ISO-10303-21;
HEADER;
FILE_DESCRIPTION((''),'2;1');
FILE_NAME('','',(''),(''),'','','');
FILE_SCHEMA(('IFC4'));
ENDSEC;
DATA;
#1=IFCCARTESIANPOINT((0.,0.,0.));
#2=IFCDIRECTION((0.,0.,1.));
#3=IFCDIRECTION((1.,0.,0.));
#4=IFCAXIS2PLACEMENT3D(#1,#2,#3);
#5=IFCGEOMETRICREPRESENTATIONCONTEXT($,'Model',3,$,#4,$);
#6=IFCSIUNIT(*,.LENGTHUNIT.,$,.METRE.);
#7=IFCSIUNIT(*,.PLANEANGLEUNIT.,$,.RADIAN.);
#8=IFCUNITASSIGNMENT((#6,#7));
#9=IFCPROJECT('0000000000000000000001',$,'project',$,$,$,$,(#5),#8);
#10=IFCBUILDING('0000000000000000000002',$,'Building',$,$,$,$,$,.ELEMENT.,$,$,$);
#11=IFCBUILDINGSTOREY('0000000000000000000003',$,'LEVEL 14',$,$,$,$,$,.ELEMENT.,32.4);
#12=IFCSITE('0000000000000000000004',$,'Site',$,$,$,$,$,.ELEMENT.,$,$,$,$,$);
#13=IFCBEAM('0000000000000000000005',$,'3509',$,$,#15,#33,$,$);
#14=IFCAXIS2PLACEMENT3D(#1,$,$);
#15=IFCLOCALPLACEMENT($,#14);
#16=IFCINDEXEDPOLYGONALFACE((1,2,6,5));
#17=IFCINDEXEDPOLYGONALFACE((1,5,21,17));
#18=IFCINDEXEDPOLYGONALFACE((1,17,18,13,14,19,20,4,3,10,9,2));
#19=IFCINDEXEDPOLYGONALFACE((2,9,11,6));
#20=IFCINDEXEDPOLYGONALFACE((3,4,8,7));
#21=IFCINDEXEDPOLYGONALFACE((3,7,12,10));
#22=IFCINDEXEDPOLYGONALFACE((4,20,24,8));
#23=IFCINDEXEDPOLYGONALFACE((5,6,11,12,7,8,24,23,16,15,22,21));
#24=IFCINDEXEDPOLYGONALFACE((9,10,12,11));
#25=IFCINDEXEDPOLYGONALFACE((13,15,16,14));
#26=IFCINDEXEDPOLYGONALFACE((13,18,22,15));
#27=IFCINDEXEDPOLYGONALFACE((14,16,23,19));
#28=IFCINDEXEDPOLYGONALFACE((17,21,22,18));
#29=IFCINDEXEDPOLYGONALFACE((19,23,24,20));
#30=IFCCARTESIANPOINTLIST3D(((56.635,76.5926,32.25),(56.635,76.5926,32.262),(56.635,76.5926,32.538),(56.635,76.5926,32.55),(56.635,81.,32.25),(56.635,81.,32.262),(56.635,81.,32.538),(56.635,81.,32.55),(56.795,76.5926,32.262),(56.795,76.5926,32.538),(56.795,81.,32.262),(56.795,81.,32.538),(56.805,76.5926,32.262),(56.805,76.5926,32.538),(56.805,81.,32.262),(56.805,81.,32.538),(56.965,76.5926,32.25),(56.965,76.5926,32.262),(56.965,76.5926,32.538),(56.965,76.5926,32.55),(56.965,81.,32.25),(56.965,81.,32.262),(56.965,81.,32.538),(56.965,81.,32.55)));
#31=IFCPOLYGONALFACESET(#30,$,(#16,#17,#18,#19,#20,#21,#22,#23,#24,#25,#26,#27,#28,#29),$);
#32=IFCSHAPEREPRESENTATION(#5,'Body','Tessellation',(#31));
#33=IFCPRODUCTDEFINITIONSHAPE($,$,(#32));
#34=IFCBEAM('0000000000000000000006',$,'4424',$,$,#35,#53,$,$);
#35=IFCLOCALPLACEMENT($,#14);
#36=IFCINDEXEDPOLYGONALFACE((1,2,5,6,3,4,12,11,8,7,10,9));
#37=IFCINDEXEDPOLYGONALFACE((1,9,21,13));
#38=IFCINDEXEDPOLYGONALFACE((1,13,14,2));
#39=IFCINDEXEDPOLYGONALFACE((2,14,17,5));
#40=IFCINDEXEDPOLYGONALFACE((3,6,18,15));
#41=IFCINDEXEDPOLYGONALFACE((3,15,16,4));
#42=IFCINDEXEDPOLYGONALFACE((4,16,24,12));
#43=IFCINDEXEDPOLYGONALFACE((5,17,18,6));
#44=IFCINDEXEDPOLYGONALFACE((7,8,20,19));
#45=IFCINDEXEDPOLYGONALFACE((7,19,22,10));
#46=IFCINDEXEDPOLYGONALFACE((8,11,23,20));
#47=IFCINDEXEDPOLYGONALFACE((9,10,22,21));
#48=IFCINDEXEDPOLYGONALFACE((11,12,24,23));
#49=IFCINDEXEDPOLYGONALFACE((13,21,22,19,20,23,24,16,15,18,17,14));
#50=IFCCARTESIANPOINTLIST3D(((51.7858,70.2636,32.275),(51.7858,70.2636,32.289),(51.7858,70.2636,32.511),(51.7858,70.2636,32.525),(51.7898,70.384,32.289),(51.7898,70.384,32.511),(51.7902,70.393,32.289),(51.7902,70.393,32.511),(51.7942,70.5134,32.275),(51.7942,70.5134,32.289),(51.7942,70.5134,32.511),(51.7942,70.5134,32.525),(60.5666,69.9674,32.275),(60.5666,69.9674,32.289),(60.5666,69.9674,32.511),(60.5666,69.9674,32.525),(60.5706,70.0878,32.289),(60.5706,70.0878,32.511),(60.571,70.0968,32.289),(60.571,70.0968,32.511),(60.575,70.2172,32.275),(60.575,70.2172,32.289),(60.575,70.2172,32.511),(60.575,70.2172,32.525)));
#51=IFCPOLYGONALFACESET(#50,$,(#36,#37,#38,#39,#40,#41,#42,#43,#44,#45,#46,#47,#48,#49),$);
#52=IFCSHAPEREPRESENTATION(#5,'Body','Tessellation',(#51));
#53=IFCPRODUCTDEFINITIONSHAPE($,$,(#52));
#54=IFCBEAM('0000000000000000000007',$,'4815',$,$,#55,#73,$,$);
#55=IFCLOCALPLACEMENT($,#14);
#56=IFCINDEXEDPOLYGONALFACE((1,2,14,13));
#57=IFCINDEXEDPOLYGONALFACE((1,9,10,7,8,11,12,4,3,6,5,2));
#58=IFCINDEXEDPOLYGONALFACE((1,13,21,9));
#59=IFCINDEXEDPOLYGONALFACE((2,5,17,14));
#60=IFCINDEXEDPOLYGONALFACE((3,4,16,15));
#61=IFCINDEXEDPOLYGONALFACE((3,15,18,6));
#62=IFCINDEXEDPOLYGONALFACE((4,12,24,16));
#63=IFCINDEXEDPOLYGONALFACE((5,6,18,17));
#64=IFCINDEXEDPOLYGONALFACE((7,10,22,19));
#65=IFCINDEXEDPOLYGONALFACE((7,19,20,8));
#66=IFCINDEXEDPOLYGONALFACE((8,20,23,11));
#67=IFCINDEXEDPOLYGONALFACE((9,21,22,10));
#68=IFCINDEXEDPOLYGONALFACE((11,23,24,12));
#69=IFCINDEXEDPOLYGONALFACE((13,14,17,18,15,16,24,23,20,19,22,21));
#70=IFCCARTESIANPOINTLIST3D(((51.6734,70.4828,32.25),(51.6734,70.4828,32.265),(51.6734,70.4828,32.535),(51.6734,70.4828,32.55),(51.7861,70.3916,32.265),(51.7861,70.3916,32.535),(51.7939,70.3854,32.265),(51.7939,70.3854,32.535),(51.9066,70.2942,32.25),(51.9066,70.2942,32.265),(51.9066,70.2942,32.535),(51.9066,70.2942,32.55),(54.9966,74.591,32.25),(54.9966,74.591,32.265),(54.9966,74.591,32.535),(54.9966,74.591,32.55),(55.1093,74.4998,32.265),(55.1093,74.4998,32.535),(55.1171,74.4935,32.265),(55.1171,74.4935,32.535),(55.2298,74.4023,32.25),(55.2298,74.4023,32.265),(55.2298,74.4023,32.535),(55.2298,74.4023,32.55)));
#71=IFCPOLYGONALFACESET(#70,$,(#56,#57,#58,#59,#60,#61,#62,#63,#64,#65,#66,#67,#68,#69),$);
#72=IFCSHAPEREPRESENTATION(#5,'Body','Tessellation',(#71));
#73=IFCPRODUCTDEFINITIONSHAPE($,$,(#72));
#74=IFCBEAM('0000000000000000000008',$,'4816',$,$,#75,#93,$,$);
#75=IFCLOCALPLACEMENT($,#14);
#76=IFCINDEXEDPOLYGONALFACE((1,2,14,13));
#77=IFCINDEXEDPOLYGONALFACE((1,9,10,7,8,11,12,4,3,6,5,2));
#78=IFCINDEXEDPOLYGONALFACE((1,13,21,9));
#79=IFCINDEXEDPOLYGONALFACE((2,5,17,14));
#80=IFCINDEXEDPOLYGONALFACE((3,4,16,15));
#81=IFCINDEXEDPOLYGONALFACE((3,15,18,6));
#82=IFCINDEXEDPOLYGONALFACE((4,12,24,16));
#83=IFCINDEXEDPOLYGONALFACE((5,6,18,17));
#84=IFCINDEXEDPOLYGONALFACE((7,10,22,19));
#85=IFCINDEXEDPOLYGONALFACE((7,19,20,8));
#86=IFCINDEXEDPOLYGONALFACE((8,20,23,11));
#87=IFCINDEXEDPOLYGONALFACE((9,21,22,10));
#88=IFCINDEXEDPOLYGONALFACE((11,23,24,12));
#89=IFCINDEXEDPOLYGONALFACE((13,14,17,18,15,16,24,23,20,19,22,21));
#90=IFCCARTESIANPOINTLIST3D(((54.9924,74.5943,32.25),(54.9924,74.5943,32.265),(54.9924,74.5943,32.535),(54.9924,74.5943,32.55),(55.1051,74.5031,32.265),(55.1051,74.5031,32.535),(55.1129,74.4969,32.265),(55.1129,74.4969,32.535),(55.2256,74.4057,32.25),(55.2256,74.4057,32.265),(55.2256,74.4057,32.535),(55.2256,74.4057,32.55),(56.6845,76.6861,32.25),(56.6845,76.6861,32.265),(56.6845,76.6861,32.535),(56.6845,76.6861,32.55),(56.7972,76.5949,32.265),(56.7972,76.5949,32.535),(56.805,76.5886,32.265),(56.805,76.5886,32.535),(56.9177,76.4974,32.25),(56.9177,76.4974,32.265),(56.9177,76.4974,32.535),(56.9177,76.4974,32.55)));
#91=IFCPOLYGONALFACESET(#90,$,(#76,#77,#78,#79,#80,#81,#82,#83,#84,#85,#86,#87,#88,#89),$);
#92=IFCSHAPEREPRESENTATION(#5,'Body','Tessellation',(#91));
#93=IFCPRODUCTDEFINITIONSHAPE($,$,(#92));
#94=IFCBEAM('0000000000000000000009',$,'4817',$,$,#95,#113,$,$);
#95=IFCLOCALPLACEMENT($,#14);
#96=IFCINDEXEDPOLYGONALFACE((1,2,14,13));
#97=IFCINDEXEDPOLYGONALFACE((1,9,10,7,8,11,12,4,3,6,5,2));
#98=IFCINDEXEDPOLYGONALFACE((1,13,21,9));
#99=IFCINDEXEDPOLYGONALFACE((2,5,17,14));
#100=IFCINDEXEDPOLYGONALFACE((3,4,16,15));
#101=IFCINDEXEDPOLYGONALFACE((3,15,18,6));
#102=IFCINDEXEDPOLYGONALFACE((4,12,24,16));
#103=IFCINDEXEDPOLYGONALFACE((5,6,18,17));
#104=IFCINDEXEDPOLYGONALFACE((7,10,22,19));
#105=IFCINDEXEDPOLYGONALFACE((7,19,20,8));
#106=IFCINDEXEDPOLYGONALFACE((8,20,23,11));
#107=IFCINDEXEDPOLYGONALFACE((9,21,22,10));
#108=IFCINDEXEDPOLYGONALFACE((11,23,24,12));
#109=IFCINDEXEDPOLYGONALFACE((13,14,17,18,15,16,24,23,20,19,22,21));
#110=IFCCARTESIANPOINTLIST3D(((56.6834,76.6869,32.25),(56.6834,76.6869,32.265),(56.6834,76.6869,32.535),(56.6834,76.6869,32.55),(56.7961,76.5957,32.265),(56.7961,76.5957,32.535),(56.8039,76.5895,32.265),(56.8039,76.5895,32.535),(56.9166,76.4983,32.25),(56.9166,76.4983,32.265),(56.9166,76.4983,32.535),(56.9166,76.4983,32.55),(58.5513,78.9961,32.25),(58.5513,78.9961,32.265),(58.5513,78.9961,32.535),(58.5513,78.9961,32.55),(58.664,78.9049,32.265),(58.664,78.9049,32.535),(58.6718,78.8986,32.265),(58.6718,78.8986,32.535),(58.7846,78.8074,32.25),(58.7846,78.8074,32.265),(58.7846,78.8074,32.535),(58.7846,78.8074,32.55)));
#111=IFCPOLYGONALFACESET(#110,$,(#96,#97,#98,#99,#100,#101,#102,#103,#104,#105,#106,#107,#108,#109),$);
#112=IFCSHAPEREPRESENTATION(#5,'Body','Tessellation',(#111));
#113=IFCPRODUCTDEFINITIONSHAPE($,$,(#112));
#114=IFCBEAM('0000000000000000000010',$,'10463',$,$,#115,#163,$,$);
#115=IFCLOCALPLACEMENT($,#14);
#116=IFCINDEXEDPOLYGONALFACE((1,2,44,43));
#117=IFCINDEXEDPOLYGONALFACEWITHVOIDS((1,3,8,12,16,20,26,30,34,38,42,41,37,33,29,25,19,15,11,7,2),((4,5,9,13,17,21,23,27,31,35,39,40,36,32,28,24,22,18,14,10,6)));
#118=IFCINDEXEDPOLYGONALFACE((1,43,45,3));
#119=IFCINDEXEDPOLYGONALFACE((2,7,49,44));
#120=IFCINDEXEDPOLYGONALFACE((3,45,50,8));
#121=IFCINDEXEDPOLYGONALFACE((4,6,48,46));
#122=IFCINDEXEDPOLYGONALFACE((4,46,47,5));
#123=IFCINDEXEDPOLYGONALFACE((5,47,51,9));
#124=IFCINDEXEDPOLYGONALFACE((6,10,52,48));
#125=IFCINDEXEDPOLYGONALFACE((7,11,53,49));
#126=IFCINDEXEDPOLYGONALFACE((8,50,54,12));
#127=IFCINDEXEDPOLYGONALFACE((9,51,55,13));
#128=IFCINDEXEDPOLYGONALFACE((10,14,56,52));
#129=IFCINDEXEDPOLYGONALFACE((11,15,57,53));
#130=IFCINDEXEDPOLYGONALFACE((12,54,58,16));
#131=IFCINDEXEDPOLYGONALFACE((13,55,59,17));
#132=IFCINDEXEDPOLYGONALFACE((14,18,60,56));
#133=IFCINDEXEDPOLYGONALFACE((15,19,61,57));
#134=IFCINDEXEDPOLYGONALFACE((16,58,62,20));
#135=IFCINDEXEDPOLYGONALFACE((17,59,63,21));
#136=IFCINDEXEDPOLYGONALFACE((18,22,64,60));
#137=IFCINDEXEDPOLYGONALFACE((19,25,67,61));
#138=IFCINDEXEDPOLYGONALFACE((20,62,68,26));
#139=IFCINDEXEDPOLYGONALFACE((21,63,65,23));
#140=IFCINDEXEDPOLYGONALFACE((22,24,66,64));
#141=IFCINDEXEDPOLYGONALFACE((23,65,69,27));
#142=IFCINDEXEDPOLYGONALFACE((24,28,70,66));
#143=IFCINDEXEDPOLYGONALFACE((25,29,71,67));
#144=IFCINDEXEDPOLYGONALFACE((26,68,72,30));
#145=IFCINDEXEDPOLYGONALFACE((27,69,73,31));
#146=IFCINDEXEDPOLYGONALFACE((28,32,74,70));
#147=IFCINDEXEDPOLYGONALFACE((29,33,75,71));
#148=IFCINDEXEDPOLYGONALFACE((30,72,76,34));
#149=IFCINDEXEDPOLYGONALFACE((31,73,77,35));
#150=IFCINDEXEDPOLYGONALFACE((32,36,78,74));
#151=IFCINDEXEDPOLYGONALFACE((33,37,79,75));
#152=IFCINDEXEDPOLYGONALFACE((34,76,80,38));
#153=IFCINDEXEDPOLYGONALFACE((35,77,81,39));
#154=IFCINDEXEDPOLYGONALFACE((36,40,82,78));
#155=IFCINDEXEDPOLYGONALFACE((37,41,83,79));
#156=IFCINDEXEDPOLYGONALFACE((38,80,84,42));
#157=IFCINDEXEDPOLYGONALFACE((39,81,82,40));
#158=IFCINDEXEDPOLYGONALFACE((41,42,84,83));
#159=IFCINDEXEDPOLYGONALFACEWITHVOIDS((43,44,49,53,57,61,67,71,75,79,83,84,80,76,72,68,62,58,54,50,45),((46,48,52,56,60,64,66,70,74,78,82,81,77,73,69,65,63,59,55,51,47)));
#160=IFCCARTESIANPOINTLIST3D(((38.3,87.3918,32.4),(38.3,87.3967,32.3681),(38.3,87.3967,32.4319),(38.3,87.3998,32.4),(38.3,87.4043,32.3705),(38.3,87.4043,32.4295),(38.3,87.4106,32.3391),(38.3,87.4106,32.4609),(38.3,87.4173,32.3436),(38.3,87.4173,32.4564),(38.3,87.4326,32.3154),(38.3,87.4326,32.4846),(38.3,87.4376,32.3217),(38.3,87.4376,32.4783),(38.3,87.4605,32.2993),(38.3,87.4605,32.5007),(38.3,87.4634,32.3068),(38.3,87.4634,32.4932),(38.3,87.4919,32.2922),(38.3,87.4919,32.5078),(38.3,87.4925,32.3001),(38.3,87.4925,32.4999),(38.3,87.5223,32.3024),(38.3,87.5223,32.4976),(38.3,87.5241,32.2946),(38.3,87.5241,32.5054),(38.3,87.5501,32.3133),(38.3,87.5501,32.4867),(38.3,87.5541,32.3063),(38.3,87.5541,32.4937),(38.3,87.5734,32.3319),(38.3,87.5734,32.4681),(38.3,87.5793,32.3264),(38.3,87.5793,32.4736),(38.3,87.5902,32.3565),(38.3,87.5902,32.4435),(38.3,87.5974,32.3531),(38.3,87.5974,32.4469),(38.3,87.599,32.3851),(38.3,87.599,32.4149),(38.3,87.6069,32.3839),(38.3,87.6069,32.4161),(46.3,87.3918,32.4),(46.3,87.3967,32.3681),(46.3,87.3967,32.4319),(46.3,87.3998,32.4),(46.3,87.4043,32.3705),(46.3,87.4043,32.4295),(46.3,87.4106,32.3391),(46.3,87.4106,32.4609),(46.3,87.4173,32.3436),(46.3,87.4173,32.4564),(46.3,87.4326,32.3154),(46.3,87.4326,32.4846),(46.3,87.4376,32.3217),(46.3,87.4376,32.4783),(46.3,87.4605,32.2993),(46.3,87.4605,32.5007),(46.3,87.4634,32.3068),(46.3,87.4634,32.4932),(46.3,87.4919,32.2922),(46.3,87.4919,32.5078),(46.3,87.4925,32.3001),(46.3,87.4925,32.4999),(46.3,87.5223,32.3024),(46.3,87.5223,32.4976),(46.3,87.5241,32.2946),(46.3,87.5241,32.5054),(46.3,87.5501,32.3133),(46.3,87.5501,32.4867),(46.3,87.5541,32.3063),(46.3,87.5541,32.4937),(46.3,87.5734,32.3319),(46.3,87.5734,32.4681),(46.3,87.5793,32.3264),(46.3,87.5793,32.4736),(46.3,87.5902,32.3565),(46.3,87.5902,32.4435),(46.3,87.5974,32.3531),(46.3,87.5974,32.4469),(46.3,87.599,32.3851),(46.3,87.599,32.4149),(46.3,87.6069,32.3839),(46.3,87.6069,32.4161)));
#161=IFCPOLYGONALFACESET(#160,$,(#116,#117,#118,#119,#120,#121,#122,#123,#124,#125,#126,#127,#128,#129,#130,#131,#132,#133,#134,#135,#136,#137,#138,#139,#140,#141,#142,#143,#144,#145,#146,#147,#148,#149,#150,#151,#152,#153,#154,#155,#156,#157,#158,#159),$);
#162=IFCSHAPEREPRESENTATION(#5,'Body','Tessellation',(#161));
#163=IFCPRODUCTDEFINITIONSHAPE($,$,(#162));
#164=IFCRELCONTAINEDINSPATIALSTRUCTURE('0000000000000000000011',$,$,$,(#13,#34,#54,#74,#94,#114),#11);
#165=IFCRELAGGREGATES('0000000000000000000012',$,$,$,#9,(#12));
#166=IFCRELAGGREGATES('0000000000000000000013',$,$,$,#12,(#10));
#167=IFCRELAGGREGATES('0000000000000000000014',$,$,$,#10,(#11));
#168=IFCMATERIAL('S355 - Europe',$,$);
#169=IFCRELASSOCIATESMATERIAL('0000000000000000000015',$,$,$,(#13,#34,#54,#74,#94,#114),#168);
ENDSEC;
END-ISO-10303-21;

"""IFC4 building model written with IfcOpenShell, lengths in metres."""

from ifc_helpers import new_model, si_unit, frame, origin_with_axes, origin_2d_with_axis, place, context, project, spatial, hollow_circle, i_section, extrude, material, material_profile, profile_set, profile_usage, element, save


model = new_model("IFC4")

# Units and contexts
model_context = context("Model", 3, world=origin_with_axes())
ifc_project = project(units=[si_unit("LENGTHUNIT", "METRE"), si_unit("PLANEANGLEUNIT", "RADIAN")], contexts=[model_context])

# Site, building, storey
site = spatial("IfcSite", under=ifc_project, Name="Site", CompositionType="ELEMENT")
building = spatial("IfcBuilding", under=site, Name="Building", CompositionType="ELEMENT")
storey = spatial("IfcBuildingStorey", under=building, Name="LEVEL 14", CompositionType="ELEMENT", Elevation=32.4)

# Shared definitions
ifc_material = material(Name="S355 - Europe")

# Beams
ifc_material_profile_1 = material_profile(ifc_material, i_section(OverallWidth=0.33, OverallDepth=0.3, WebThickness=0.01, FlangeThickness=0.012, at=origin_2d_with_axis()))
ifc_profile_set_1 = profile_set([ifc_material_profile_1])
ifc_profile_usage_1 = profile_usage(ifc_profile_set_1, cardinal=10)
beam_1_placement = place(None, frame((56.8, 81.0, 32.4), z_axis=(0.0, -1.0, 0.0), x_axis=(1.0, 0.0, 0.0)))
element("IfcBeam", 1, at=beam_1_placement, inside=storey, material=ifc_profile_usage_1, Name="3509", context=model_context, shape_type="SweptSolid", body=[
    extrude(i_section(OverallWidth=0.33, OverallDepth=0.3, WebThickness=0.01, FlangeThickness=0.012, at=origin_2d_with_axis()), origin_with_axes(), (0.0, 0.0, 1.0), 4.4074),
])
ifc_material_profile_2 = material_profile(ifc_material, i_section(OverallWidth=0.25, OverallDepth=0.25, WebThickness=0.009, FlangeThickness=0.014, at=origin_2d_with_axis()))
ifc_profile_set_2 = profile_set([ifc_material_profile_2])
ifc_profile_usage_2 = profile_usage(ifc_profile_set_2, cardinal=10)
beam_2_placement = place(None, frame((51.79, 70.3885, 32.4), z_axis=(0.999432, -0.033714, 0.0), x_axis=(0.033714, 0.999432, 0.0)))
element("IfcBeam", 2, at=beam_2_placement, inside=storey, material=ifc_profile_usage_2, Name="4424", context=model_context, shape_type="SweptSolid", body=[
    extrude(i_section(OverallWidth=0.25, OverallDepth=0.25, WebThickness=0.009, FlangeThickness=0.014, at=origin_2d_with_axis()), origin_with_axes(), (0.0, 0.0, 1.0), 8.7858),
])
ifc_material_profile_3 = material_profile(ifc_material, i_section(OverallWidth=0.3, OverallDepth=0.3, WebThickness=0.01, FlangeThickness=0.015, at=origin_2d_with_axis()))
ifc_profile_set_3 = profile_set([ifc_material_profile_3])
ifc_profile_usage_3 = profile_usage(ifc_profile_set_3, cardinal=10)
beam_3_placement = place(None, frame((51.79, 70.3885, 32.4), z_axis=(0.62892, 0.77747, 0.0), x_axis=(-0.777826, 0.62848, 0.0)))
element("IfcBeam", 3, at=beam_3_placement, inside=storey, material=ifc_profile_usage_3, Name="4815", context=model_context, shape_type="SweptSolid", body=[
    extrude(i_section(OverallWidth=0.3, OverallDepth=0.3, WebThickness=0.01, FlangeThickness=0.015, at=origin_2d_with_axis()), origin_with_axes(), (0.0, 0.0, 1.0), 5.284),
])
ifc_material_profile_4 = material_profile(ifc_material, i_section(OverallWidth=0.3, OverallDepth=0.3, WebThickness=0.01, FlangeThickness=0.015, at=origin_2d_with_axis()))
ifc_profile_set_4 = profile_set([ifc_material_profile_4])
ifc_profile_usage_4 = profile_usage(ifc_profile_set_4, cardinal=10)
beam_4_placement = place(None, frame((55.109, 74.5, 32.4), z_axis=(0.62892, 0.77747, 0.0), x_axis=(-0.777826, 0.62848, 0.0)))
element("IfcBeam", 4, at=beam_4_placement, inside=storey, material=ifc_profile_usage_4, Name="4816", context=model_context, shape_type="SweptSolid", body=[
    extrude(i_section(OverallWidth=0.3, OverallDepth=0.3, WebThickness=0.01, FlangeThickness=0.015, at=origin_2d_with_axis()), origin_with_axes(), (0.0, 0.0, 1.0), 2.6904),
])
ifc_material_profile_5 = material_profile(ifc_material, i_section(OverallWidth=0.3, OverallDepth=0.3, WebThickness=0.01, FlangeThickness=0.015, at=origin_2d_with_axis()))
ifc_profile_set_5 = profile_set([ifc_material_profile_5])
ifc_profile_usage_5 = profile_usage(ifc_profile_set_5, cardinal=10)
beam_5_placement = place(None, frame((56.8, 76.5926, 32.4), z_axis=(0.62892, 0.77747, 0.0), x_axis=(-0.777826, 0.62848, 0.0)))
element("IfcBeam", 5, at=beam_5_placement, inside=storey, material=ifc_profile_usage_5, Name="4817", context=model_context, shape_type="SweptSolid", body=[
    extrude(i_section(OverallWidth=0.3, OverallDepth=0.3, WebThickness=0.01, FlangeThickness=0.015, at=origin_2d_with_axis()), origin_with_axes(), (0.0, 0.0, 1.0), 2.9701),
])
ifc_material_profile_6 = material_profile(ifc_material, hollow_circle(Radius=0.1081, WallThickness=0.008, at=origin_2d_with_axis()))
ifc_profile_set_6 = profile_set([ifc_material_profile_6])
ifc_profile_usage_6 = profile_usage(ifc_profile_set_6, cardinal=10)
beam_6_placement = place(None, frame((46.3, 87.5, 32.4), z_axis=(-1.0, 0.0, 0.0), x_axis=(0.0, -1.0, 0.0)))
element("IfcBeam", 6, at=beam_6_placement, inside=storey, material=ifc_profile_usage_6, Name="10463", context=model_context, shape_type="SweptSolid", body=[
    extrude(hollow_circle(Radius=0.1081, WallThickness=0.008, at=origin_2d_with_axis()), origin_with_axes(), (0.0, 0.0, 1.0), 8.0),
])

save(model, "model.ifc")
